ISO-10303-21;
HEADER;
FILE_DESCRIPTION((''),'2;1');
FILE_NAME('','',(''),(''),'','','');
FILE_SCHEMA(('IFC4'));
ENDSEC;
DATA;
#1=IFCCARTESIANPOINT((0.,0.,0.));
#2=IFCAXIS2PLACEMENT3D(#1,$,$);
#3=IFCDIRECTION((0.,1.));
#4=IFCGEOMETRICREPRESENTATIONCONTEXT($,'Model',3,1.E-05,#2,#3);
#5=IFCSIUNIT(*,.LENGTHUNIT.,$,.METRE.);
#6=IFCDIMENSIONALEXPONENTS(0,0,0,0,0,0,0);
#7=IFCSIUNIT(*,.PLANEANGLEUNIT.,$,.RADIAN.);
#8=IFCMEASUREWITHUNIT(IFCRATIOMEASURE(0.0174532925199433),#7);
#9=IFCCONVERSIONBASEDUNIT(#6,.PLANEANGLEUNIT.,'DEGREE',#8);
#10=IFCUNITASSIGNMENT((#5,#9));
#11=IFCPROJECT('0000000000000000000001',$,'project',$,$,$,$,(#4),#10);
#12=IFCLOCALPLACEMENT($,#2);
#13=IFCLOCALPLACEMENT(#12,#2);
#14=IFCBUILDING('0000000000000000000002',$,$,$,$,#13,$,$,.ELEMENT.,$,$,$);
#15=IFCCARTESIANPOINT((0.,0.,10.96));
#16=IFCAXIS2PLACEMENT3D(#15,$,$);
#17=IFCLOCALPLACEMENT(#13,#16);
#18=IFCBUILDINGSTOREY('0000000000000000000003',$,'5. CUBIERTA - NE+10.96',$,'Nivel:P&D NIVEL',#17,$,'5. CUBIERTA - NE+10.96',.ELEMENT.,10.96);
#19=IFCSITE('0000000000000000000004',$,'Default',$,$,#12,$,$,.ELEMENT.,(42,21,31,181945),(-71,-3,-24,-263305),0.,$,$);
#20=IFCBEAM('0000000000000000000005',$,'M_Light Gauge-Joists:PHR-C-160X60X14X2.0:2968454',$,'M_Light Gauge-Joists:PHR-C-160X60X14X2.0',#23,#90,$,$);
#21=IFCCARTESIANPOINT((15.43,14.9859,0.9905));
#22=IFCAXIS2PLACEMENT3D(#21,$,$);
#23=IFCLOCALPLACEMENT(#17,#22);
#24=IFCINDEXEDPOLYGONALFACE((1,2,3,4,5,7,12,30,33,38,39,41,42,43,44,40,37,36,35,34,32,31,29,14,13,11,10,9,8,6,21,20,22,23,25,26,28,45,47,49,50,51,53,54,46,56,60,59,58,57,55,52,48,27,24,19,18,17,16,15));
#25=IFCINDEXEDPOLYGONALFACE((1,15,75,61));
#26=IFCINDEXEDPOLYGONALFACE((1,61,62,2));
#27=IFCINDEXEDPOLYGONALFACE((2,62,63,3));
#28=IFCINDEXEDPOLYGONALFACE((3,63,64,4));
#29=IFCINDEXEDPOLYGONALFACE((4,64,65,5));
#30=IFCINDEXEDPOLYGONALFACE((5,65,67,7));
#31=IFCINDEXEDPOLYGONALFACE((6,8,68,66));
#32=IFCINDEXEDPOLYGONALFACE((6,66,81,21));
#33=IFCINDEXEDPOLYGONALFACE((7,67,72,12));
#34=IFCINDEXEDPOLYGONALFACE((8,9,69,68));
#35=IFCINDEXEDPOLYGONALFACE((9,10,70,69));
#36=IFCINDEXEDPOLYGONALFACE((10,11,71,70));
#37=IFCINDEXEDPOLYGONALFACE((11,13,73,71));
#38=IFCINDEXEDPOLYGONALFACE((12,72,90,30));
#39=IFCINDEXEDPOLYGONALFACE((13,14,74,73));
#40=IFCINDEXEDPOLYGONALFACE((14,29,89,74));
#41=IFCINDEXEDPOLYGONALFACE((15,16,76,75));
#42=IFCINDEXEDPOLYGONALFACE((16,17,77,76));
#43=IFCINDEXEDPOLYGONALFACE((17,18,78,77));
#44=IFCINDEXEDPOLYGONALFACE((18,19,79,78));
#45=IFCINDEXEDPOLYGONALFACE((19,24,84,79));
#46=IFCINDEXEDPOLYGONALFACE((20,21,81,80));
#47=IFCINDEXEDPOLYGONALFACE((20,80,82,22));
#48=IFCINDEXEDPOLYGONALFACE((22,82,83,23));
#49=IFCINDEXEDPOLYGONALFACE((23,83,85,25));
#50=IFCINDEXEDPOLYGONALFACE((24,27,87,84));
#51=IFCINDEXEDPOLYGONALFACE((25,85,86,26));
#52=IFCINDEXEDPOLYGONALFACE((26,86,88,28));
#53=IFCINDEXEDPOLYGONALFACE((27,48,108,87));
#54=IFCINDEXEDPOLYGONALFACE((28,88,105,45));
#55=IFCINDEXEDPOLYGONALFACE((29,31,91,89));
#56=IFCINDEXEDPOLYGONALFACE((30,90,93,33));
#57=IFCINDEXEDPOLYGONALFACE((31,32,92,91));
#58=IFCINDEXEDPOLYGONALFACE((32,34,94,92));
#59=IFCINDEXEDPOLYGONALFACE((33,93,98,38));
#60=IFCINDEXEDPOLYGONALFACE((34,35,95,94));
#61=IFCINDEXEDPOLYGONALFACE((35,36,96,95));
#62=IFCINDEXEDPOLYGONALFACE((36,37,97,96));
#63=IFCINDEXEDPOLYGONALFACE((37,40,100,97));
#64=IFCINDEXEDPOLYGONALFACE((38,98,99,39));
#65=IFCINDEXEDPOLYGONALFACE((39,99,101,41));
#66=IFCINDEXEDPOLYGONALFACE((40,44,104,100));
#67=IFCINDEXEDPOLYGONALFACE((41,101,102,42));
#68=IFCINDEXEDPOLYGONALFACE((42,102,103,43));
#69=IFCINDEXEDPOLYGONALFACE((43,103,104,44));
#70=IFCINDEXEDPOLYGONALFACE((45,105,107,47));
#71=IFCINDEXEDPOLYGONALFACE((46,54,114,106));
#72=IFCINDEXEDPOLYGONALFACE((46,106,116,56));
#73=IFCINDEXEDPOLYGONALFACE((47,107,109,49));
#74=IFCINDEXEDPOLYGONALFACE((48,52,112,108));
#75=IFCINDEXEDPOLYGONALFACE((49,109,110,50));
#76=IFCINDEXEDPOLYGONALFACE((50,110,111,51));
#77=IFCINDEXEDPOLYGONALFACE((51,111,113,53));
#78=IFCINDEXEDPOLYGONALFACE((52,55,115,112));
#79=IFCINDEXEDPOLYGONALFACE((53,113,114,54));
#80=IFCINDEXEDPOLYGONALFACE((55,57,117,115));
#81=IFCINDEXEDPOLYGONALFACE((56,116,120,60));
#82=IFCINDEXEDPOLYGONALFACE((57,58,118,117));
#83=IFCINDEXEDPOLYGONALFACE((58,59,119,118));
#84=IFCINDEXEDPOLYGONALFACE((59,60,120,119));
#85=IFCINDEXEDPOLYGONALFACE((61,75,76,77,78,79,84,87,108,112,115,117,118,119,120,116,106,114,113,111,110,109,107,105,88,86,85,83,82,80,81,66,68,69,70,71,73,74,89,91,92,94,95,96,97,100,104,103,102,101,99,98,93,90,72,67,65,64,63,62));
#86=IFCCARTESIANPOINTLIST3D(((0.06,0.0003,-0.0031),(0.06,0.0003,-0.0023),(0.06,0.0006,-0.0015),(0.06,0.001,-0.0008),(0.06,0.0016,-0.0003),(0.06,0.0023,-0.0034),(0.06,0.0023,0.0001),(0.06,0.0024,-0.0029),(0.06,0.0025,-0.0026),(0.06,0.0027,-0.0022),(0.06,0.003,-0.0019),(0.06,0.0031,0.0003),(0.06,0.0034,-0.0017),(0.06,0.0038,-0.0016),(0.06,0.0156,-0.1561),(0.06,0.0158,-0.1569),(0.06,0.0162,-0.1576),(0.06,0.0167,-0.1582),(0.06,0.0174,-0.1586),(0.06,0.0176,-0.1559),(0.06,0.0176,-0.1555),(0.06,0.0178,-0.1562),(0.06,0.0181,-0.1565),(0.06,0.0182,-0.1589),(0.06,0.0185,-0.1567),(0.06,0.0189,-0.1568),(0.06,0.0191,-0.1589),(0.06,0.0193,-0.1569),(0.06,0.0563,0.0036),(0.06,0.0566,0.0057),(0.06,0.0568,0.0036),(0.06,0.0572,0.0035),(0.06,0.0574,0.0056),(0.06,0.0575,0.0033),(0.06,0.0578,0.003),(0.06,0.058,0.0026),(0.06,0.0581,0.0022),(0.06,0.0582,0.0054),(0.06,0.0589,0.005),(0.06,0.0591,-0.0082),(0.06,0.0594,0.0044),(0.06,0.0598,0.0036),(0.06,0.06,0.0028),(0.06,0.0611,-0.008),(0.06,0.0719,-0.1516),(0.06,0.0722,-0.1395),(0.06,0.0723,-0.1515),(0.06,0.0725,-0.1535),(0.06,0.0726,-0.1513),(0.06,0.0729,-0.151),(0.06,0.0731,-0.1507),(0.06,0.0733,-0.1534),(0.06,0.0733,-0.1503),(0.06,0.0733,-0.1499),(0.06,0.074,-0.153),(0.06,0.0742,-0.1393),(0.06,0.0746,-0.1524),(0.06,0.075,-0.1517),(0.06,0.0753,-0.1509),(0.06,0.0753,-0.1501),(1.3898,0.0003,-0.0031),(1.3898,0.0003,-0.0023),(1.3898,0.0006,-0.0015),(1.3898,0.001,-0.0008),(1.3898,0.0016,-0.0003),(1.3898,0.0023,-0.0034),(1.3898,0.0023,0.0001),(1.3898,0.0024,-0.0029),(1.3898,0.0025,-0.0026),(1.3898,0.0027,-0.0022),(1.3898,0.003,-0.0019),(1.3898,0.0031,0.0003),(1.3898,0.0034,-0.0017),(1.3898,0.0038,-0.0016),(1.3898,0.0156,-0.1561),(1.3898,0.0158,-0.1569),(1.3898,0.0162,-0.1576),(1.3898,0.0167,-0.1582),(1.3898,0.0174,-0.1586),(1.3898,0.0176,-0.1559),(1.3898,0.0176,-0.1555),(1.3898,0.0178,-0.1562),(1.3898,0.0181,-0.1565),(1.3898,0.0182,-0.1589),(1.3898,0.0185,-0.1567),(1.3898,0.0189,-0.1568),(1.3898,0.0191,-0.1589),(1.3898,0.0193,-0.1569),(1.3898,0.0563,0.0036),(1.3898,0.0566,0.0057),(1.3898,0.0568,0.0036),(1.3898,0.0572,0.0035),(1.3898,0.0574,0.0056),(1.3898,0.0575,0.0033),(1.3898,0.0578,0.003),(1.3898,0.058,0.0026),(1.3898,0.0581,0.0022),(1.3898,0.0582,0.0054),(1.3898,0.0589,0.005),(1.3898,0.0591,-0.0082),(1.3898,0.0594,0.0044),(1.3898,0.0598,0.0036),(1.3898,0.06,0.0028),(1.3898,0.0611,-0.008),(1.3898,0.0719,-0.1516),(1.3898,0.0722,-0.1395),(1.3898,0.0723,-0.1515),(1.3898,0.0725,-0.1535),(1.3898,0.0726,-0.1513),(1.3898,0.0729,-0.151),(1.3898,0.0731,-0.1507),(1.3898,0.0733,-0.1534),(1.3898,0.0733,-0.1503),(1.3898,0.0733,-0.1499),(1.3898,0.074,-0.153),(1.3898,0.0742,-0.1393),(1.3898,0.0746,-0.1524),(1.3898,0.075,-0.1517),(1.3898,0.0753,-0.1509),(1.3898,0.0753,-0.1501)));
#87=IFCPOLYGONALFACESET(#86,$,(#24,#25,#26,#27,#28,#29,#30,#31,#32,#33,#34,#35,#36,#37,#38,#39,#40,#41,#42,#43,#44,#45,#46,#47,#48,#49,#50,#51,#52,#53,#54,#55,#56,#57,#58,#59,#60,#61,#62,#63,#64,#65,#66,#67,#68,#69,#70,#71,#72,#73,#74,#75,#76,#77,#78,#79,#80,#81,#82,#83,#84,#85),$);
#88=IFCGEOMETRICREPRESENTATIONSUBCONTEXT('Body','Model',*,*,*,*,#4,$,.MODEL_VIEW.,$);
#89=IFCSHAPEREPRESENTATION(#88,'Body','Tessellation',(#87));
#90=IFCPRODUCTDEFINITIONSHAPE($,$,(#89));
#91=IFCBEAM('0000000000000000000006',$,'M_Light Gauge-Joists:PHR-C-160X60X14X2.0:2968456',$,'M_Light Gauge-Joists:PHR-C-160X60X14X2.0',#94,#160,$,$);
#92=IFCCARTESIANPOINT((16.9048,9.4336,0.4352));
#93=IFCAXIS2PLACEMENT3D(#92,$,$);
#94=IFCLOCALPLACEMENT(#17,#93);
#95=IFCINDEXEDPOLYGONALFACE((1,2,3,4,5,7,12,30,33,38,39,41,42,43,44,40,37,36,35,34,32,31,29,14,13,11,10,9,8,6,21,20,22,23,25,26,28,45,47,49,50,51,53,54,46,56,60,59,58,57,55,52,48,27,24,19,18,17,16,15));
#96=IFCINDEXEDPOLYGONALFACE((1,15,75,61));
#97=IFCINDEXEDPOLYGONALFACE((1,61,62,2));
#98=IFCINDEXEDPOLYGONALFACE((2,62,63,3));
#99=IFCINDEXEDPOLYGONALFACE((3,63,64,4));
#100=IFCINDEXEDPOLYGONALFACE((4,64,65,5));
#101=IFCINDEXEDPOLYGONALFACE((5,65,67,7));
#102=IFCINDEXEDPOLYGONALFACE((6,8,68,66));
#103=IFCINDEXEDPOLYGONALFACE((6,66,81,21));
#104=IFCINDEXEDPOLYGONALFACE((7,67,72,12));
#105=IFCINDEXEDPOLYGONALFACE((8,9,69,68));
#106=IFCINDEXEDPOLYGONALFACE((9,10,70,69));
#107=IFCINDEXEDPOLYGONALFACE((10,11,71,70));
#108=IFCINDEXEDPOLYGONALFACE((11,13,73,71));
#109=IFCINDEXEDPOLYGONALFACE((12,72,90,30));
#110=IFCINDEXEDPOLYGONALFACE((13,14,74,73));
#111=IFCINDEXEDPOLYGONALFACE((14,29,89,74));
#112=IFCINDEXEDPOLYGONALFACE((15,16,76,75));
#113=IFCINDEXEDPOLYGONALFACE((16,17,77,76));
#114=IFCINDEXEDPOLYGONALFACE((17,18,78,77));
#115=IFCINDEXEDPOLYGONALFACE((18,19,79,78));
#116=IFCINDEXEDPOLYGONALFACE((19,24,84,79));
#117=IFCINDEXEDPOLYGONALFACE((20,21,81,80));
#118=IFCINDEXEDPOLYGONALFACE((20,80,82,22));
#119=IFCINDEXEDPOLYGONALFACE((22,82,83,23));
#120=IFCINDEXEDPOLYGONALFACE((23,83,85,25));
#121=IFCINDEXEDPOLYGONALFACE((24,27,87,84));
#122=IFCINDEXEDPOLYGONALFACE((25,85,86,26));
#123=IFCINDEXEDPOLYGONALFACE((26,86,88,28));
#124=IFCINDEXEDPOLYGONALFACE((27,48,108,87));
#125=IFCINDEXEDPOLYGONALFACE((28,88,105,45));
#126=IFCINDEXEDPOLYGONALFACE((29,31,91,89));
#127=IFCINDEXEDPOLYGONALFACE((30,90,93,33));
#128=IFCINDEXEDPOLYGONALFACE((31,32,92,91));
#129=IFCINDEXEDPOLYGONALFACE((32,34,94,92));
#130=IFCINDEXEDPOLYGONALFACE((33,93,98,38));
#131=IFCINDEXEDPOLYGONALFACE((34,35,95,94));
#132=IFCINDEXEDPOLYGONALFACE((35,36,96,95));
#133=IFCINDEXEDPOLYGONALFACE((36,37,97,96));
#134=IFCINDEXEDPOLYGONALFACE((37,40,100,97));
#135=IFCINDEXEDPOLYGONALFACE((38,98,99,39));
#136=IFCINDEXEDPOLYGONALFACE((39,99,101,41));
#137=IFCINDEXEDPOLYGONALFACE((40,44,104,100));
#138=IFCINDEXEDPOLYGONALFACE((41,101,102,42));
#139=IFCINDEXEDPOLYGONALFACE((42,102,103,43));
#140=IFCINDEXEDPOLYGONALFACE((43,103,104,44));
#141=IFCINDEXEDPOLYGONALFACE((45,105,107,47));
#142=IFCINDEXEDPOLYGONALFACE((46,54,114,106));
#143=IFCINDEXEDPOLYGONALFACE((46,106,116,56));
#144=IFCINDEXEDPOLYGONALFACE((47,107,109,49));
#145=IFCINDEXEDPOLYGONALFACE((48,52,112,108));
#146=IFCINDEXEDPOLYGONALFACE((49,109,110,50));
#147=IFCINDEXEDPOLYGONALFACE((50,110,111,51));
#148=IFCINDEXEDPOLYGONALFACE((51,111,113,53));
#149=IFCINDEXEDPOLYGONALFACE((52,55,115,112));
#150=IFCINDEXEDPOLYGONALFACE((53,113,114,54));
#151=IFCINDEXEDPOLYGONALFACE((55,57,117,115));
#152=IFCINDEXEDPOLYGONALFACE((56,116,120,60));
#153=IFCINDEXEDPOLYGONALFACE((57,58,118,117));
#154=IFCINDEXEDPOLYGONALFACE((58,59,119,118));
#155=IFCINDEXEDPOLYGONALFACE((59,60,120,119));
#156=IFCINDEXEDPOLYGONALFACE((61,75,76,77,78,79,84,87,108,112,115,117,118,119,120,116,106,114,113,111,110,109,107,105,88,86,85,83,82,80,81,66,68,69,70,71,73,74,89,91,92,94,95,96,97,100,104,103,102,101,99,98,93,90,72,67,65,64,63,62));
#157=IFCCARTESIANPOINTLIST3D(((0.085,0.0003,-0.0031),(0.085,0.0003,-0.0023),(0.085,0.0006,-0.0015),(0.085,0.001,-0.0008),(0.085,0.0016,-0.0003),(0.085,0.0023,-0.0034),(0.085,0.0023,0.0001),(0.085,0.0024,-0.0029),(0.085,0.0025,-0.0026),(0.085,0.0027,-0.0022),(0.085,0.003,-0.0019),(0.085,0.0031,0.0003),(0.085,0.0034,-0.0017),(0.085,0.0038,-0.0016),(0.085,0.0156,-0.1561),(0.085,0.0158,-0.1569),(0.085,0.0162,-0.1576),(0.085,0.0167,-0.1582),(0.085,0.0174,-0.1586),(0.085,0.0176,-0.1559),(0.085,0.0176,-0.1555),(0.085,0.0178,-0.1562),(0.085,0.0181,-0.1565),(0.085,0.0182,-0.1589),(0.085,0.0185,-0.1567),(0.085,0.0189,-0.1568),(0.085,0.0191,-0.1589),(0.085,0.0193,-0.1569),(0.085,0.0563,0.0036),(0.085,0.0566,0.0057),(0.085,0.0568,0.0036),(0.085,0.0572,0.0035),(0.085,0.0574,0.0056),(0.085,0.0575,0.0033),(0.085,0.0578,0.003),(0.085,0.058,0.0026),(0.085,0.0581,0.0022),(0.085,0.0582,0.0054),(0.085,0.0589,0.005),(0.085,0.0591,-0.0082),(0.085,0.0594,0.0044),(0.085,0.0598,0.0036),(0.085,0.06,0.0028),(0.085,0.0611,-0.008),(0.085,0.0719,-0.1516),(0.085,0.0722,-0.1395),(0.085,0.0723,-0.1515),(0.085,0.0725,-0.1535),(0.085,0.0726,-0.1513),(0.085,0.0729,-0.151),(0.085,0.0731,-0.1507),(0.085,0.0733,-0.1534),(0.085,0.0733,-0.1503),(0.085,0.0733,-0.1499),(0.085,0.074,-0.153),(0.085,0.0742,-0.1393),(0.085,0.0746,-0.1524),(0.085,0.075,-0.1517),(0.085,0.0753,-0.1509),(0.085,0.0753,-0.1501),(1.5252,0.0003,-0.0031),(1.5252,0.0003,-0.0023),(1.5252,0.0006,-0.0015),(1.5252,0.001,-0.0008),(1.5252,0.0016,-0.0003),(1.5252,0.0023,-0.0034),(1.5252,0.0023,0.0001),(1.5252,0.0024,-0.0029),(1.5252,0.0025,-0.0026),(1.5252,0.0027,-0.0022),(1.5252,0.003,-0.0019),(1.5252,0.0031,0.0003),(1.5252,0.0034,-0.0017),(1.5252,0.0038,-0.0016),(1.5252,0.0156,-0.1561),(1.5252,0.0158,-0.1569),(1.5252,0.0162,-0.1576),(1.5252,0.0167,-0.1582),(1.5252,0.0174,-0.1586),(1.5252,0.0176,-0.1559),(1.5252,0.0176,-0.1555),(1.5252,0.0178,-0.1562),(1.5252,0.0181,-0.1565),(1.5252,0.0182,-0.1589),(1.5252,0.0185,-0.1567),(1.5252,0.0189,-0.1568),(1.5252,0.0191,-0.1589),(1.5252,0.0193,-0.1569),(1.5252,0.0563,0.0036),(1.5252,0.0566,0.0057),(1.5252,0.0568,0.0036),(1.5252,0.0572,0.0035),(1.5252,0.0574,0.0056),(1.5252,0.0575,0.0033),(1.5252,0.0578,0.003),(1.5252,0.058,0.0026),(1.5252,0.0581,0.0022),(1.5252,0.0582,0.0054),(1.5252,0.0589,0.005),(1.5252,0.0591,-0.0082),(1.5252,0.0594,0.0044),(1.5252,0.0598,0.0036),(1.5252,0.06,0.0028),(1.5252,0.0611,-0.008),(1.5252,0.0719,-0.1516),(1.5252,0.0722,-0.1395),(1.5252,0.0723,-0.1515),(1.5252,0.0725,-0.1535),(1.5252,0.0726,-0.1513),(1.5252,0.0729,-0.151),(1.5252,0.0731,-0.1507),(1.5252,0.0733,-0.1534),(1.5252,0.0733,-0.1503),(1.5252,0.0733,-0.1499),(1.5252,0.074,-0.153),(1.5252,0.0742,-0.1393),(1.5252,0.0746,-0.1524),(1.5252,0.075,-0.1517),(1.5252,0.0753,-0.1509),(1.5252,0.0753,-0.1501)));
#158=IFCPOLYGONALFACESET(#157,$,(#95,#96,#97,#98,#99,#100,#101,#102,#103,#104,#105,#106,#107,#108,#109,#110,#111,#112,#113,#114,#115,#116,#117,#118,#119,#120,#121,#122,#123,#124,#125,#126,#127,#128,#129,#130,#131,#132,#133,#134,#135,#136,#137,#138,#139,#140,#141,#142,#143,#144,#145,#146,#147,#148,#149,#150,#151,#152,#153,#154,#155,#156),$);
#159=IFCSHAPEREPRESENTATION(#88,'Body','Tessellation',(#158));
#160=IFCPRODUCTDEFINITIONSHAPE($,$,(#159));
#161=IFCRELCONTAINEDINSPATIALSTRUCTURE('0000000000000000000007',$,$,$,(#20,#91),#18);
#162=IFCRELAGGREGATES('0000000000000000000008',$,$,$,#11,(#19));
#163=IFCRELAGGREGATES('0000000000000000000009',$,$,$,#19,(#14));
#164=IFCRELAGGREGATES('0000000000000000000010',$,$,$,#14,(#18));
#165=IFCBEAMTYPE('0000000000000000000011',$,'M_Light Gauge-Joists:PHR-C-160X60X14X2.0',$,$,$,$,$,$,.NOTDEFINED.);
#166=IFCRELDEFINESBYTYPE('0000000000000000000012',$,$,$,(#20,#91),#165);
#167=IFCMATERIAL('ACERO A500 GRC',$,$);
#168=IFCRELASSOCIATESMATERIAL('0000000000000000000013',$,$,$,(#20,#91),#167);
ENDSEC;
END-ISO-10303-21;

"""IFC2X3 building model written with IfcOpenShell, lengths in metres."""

from ifc_helpers import new_model, entity, si_unit, converted_unit, direction, frame, frame_2d, origin, place, context, subcontext, project, spatial, polyline, circle_curve, parameter, trimmed, segment, composite_curve, outline, extrude, material, type_object, element, save


model = new_model("IFC2X3")

# Units and contexts
model_context = context("Model", 3, precision=1e-05, world=origin(), true_north=direction((0.0, 1.0)))
body_context = subcontext(model_context, "Body", "Model", "MODEL_VIEW")
ifc_project = project(units=[si_unit("LENGTHUNIT", "METRE"), converted_unit("PLANEANGLEUNIT", "DEGREE", entity("IfcRatioMeasure", 0.0174532925199433), si_unit("PLANEANGLEUNIT", "RADIAN"), dimensions=[0, 0, 0, 0, 0, 0, 0])], contexts=[model_context])

# Site, building, storey
site_placement = place(None, origin())
site = spatial("IfcSite", under=ifc_project, at=site_placement, Name="Default", CompositionType="ELEMENT", RefLatitude=(42, 21, 31, 181945), RefLongitude=(-71, -3, -24, -263305), RefElevation=0.0)
building_placement = place(site_placement, origin())
building = spatial("IfcBuilding", under=site, at=building_placement, CompositionType="ELEMENT")
storey_placement = place(building_placement, frame((0.0, 0.0, 10.96)))
storey = spatial("IfcBuildingStorey", under=building, at=storey_placement, Name="5. CUBIERTA - NE+10.96", ObjectType="Nivel:P&D NIVEL", LongName="5. CUBIERTA - NE+10.96", CompositionType="ELEMENT", Elevation=10.96)

# Beams
ifc_material_1 = material(Name="ACERO A500 GRC")
beam_type_1 = type_object("IfcBeamType", Name="M_Light Gauge-Joists:PHR-C-160X60X14X2.0", PredefinedType="NOTDEFINED")
beam_1_placement = place(storey_placement, frame((15.43, 14.9859, 0.9905)))
element("IfcBeam", 1, at=beam_1_placement, inside=storey, type_object=beam_type_1, material=ifc_material_1, Name="M_Light Gauge-Joists:PHR-C-160X60X14X2.0:2968454", ObjectType="M_Light Gauge-Joists:PHR-C-160X60X14X2.0", context=body_context, shape_type="SweptSolid", body=[
    extrude(outline(composite_curve([segment(trimmed(circle_curve(frame_2d((-0.0764, -0.0322), x_axis=(-1.0, 0.0)), 0.0016), [parameter(0.0)], [parameter(90.0)], True, "PARAMETER"), False, "CONTINUOUS"), segment(polyline([(-0.078, -0.0322), (-0.078, 0.0206)]), True, "CONTINUOUS"), segment(trimmed(circle_curve(frame_2d((-0.0764, 0.0206), x_axis=(0.0, 1.0)), 0.0016), [parameter(0.0)], [parameter(90.0)], True, "PARAMETER"), False, "CONTINUOUS"), segment(polyline([(-0.0764, 0.0222), (-0.066, 0.0222)]), True, "CONTINUOUS"), segment(polyline([(-0.066, 0.0222), (-0.066, 0.0242)]), True, "CONTINUOUS"), segment(polyline([(-0.066, 0.0242), (-0.0768, 0.0242)]), True, "CONTINUOUS"), segment(trimmed(circle_curve(frame_2d((-0.0768, 0.021), x_axis=(-1.0, 0.0)), 0.0032), [parameter(270.0)], [parameter(0.0)], True, "PARAMETER"), True, "CONTINUOUS"), segment(polyline([(-0.08, 0.021), (-0.08, -0.0326)]), True, "CONTINUOUS"), segment(trimmed(circle_curve(frame_2d((-0.0768, -0.0326), x_axis=(0.0, -1.0)), 0.0032), [parameter(270.0)], [parameter(0.0)], True, "PARAMETER"), True, "CONTINUOUS"), segment(polyline([(-0.0768, -0.0358), (0.0768, -0.0358)]), True, "CONTINUOUS"), segment(trimmed(circle_curve(frame_2d((0.0768, -0.0326), x_axis=(1.0, 0.0)), 0.0032), [parameter(270.0)], [parameter(0.0)], True, "PARAMETER"), True, "CONTINUOUS"), segment(polyline([(0.08, -0.0326), (0.08, 0.021)]), True, "CONTINUOUS"), segment(trimmed(circle_curve(frame_2d((0.0768, 0.021), x_axis=(0.0, 1.0)), 0.0032), [parameter(270.0)], [parameter(0.0)], True, "PARAMETER"), True, "CONTINUOUS"), segment(polyline([(0.0768, 0.0242), (0.066, 0.0242)]), True, "CONTINUOUS"), segment(polyline([(0.066, 0.0242), (0.066, 0.0222)]), True, "CONTINUOUS"), segment(polyline([(0.066, 0.0222), (0.0764, 0.0222)]), True, "CONTINUOUS"), segment(trimmed(circle_curve(frame_2d((0.0764, 0.0206), x_axis=(1.0, 0.0)), 0.0016), [parameter(0.0)], [parameter(90.0)], True, "PARAMETER"), False, "CONTINUOUS"), segment(polyline([(0.078, 0.0206), (0.078, -0.0322)]), True, "CONTINUOUS"), segment(trimmed(circle_curve(frame_2d((0.0764, -0.0322), x_axis=(0.0, -1.0)), 0.0016), [parameter(0.0)], [parameter(90.0)], True, "PARAMETER"), False, "CONTINUOUS"), segment(polyline([(0.0764, -0.0338), (-0.0764, -0.0338)]), True, "CONTINUOUS")], self_intersect=False)), frame((0.06, 0.0436, -0.076), z_axis=(-1.0, 0.0, 0.0), x_axis=(0.0, -0.099504, 0.995037)), (0.0, 0.0, -1.0), 1.3298),
])
beam_2_placement = place(storey_placement, frame((16.9048, 9.4336, 0.4352)))
element("IfcBeam", 2, at=beam_2_placement, inside=storey, type_object=beam_type_1, material=ifc_material_1, Name="M_Light Gauge-Joists:PHR-C-160X60X14X2.0:2968456", ObjectType="M_Light Gauge-Joists:PHR-C-160X60X14X2.0", context=body_context, shape_type="SweptSolid", body=[
    extrude(outline(composite_curve([segment(trimmed(circle_curve(frame_2d((-0.0764, -0.0322), x_axis=(-1.0, 0.0)), 0.0016), [parameter(0.0)], [parameter(90.0)], True, "PARAMETER"), False, "CONTINUOUS"), segment(polyline([(-0.078, -0.0322), (-0.078, 0.0206)]), True, "CONTINUOUS"), segment(trimmed(circle_curve(frame_2d((-0.0764, 0.0206), x_axis=(0.0, 1.0)), 0.0016), [parameter(0.0)], [parameter(90.0)], True, "PARAMETER"), False, "CONTINUOUS"), segment(polyline([(-0.0764, 0.0222), (-0.066, 0.0222)]), True, "CONTINUOUS"), segment(polyline([(-0.066, 0.0222), (-0.066, 0.0242)]), True, "CONTINUOUS"), segment(polyline([(-0.066, 0.0242), (-0.0768, 0.0242)]), True, "CONTINUOUS"), segment(trimmed(circle_curve(frame_2d((-0.0768, 0.021), x_axis=(-1.0, 0.0)), 0.0032), [parameter(270.0)], [parameter(0.0)], True, "PARAMETER"), True, "CONTINUOUS"), segment(polyline([(-0.08, 0.021), (-0.08, -0.0326)]), True, "CONTINUOUS"), segment(trimmed(circle_curve(frame_2d((-0.0768, -0.0326), x_axis=(0.0, -1.0)), 0.0032), [parameter(270.0)], [parameter(0.0)], True, "PARAMETER"), True, "CONTINUOUS"), segment(polyline([(-0.0768, -0.0358), (0.0768, -0.0358)]), True, "CONTINUOUS"), segment(trimmed(circle_curve(frame_2d((0.0768, -0.0326), x_axis=(1.0, 0.0)), 0.0032), [parameter(270.0)], [parameter(0.0)], True, "PARAMETER"), True, "CONTINUOUS"), segment(polyline([(0.08, -0.0326), (0.08, 0.021)]), True, "CONTINUOUS"), segment(trimmed(circle_curve(frame_2d((0.0768, 0.021), x_axis=(0.0, 1.0)), 0.0032), [parameter(270.0)], [parameter(0.0)], True, "PARAMETER"), True, "CONTINUOUS"), segment(polyline([(0.0768, 0.0242), (0.066, 0.0242)]), True, "CONTINUOUS"), segment(polyline([(0.066, 0.0242), (0.066, 0.0222)]), True, "CONTINUOUS"), segment(polyline([(0.066, 0.0222), (0.0764, 0.0222)]), True, "CONTINUOUS"), segment(trimmed(circle_curve(frame_2d((0.0764, 0.0206), x_axis=(1.0, 0.0)), 0.0016), [parameter(0.0)], [parameter(90.0)], True, "PARAMETER"), False, "CONTINUOUS"), segment(polyline([(0.078, 0.0206), (0.078, -0.0322)]), True, "CONTINUOUS"), segment(trimmed(circle_curve(frame_2d((0.0764, -0.0322), x_axis=(0.0, -1.0)), 0.0016), [parameter(0.0)], [parameter(90.0)], True, "PARAMETER"), False, "CONTINUOUS"), segment(polyline([(0.0764, -0.0338), (-0.0764, -0.0338)]), True, "CONTINUOUS")], self_intersect=False)), frame((0.085, 0.0436, -0.076), z_axis=(-1.0, 0.0, 0.0), x_axis=(0.0, -0.099504, 0.995037)), (0.0, 0.0, -1.0), 1.4402),
])

save(model, "model.ifc")
